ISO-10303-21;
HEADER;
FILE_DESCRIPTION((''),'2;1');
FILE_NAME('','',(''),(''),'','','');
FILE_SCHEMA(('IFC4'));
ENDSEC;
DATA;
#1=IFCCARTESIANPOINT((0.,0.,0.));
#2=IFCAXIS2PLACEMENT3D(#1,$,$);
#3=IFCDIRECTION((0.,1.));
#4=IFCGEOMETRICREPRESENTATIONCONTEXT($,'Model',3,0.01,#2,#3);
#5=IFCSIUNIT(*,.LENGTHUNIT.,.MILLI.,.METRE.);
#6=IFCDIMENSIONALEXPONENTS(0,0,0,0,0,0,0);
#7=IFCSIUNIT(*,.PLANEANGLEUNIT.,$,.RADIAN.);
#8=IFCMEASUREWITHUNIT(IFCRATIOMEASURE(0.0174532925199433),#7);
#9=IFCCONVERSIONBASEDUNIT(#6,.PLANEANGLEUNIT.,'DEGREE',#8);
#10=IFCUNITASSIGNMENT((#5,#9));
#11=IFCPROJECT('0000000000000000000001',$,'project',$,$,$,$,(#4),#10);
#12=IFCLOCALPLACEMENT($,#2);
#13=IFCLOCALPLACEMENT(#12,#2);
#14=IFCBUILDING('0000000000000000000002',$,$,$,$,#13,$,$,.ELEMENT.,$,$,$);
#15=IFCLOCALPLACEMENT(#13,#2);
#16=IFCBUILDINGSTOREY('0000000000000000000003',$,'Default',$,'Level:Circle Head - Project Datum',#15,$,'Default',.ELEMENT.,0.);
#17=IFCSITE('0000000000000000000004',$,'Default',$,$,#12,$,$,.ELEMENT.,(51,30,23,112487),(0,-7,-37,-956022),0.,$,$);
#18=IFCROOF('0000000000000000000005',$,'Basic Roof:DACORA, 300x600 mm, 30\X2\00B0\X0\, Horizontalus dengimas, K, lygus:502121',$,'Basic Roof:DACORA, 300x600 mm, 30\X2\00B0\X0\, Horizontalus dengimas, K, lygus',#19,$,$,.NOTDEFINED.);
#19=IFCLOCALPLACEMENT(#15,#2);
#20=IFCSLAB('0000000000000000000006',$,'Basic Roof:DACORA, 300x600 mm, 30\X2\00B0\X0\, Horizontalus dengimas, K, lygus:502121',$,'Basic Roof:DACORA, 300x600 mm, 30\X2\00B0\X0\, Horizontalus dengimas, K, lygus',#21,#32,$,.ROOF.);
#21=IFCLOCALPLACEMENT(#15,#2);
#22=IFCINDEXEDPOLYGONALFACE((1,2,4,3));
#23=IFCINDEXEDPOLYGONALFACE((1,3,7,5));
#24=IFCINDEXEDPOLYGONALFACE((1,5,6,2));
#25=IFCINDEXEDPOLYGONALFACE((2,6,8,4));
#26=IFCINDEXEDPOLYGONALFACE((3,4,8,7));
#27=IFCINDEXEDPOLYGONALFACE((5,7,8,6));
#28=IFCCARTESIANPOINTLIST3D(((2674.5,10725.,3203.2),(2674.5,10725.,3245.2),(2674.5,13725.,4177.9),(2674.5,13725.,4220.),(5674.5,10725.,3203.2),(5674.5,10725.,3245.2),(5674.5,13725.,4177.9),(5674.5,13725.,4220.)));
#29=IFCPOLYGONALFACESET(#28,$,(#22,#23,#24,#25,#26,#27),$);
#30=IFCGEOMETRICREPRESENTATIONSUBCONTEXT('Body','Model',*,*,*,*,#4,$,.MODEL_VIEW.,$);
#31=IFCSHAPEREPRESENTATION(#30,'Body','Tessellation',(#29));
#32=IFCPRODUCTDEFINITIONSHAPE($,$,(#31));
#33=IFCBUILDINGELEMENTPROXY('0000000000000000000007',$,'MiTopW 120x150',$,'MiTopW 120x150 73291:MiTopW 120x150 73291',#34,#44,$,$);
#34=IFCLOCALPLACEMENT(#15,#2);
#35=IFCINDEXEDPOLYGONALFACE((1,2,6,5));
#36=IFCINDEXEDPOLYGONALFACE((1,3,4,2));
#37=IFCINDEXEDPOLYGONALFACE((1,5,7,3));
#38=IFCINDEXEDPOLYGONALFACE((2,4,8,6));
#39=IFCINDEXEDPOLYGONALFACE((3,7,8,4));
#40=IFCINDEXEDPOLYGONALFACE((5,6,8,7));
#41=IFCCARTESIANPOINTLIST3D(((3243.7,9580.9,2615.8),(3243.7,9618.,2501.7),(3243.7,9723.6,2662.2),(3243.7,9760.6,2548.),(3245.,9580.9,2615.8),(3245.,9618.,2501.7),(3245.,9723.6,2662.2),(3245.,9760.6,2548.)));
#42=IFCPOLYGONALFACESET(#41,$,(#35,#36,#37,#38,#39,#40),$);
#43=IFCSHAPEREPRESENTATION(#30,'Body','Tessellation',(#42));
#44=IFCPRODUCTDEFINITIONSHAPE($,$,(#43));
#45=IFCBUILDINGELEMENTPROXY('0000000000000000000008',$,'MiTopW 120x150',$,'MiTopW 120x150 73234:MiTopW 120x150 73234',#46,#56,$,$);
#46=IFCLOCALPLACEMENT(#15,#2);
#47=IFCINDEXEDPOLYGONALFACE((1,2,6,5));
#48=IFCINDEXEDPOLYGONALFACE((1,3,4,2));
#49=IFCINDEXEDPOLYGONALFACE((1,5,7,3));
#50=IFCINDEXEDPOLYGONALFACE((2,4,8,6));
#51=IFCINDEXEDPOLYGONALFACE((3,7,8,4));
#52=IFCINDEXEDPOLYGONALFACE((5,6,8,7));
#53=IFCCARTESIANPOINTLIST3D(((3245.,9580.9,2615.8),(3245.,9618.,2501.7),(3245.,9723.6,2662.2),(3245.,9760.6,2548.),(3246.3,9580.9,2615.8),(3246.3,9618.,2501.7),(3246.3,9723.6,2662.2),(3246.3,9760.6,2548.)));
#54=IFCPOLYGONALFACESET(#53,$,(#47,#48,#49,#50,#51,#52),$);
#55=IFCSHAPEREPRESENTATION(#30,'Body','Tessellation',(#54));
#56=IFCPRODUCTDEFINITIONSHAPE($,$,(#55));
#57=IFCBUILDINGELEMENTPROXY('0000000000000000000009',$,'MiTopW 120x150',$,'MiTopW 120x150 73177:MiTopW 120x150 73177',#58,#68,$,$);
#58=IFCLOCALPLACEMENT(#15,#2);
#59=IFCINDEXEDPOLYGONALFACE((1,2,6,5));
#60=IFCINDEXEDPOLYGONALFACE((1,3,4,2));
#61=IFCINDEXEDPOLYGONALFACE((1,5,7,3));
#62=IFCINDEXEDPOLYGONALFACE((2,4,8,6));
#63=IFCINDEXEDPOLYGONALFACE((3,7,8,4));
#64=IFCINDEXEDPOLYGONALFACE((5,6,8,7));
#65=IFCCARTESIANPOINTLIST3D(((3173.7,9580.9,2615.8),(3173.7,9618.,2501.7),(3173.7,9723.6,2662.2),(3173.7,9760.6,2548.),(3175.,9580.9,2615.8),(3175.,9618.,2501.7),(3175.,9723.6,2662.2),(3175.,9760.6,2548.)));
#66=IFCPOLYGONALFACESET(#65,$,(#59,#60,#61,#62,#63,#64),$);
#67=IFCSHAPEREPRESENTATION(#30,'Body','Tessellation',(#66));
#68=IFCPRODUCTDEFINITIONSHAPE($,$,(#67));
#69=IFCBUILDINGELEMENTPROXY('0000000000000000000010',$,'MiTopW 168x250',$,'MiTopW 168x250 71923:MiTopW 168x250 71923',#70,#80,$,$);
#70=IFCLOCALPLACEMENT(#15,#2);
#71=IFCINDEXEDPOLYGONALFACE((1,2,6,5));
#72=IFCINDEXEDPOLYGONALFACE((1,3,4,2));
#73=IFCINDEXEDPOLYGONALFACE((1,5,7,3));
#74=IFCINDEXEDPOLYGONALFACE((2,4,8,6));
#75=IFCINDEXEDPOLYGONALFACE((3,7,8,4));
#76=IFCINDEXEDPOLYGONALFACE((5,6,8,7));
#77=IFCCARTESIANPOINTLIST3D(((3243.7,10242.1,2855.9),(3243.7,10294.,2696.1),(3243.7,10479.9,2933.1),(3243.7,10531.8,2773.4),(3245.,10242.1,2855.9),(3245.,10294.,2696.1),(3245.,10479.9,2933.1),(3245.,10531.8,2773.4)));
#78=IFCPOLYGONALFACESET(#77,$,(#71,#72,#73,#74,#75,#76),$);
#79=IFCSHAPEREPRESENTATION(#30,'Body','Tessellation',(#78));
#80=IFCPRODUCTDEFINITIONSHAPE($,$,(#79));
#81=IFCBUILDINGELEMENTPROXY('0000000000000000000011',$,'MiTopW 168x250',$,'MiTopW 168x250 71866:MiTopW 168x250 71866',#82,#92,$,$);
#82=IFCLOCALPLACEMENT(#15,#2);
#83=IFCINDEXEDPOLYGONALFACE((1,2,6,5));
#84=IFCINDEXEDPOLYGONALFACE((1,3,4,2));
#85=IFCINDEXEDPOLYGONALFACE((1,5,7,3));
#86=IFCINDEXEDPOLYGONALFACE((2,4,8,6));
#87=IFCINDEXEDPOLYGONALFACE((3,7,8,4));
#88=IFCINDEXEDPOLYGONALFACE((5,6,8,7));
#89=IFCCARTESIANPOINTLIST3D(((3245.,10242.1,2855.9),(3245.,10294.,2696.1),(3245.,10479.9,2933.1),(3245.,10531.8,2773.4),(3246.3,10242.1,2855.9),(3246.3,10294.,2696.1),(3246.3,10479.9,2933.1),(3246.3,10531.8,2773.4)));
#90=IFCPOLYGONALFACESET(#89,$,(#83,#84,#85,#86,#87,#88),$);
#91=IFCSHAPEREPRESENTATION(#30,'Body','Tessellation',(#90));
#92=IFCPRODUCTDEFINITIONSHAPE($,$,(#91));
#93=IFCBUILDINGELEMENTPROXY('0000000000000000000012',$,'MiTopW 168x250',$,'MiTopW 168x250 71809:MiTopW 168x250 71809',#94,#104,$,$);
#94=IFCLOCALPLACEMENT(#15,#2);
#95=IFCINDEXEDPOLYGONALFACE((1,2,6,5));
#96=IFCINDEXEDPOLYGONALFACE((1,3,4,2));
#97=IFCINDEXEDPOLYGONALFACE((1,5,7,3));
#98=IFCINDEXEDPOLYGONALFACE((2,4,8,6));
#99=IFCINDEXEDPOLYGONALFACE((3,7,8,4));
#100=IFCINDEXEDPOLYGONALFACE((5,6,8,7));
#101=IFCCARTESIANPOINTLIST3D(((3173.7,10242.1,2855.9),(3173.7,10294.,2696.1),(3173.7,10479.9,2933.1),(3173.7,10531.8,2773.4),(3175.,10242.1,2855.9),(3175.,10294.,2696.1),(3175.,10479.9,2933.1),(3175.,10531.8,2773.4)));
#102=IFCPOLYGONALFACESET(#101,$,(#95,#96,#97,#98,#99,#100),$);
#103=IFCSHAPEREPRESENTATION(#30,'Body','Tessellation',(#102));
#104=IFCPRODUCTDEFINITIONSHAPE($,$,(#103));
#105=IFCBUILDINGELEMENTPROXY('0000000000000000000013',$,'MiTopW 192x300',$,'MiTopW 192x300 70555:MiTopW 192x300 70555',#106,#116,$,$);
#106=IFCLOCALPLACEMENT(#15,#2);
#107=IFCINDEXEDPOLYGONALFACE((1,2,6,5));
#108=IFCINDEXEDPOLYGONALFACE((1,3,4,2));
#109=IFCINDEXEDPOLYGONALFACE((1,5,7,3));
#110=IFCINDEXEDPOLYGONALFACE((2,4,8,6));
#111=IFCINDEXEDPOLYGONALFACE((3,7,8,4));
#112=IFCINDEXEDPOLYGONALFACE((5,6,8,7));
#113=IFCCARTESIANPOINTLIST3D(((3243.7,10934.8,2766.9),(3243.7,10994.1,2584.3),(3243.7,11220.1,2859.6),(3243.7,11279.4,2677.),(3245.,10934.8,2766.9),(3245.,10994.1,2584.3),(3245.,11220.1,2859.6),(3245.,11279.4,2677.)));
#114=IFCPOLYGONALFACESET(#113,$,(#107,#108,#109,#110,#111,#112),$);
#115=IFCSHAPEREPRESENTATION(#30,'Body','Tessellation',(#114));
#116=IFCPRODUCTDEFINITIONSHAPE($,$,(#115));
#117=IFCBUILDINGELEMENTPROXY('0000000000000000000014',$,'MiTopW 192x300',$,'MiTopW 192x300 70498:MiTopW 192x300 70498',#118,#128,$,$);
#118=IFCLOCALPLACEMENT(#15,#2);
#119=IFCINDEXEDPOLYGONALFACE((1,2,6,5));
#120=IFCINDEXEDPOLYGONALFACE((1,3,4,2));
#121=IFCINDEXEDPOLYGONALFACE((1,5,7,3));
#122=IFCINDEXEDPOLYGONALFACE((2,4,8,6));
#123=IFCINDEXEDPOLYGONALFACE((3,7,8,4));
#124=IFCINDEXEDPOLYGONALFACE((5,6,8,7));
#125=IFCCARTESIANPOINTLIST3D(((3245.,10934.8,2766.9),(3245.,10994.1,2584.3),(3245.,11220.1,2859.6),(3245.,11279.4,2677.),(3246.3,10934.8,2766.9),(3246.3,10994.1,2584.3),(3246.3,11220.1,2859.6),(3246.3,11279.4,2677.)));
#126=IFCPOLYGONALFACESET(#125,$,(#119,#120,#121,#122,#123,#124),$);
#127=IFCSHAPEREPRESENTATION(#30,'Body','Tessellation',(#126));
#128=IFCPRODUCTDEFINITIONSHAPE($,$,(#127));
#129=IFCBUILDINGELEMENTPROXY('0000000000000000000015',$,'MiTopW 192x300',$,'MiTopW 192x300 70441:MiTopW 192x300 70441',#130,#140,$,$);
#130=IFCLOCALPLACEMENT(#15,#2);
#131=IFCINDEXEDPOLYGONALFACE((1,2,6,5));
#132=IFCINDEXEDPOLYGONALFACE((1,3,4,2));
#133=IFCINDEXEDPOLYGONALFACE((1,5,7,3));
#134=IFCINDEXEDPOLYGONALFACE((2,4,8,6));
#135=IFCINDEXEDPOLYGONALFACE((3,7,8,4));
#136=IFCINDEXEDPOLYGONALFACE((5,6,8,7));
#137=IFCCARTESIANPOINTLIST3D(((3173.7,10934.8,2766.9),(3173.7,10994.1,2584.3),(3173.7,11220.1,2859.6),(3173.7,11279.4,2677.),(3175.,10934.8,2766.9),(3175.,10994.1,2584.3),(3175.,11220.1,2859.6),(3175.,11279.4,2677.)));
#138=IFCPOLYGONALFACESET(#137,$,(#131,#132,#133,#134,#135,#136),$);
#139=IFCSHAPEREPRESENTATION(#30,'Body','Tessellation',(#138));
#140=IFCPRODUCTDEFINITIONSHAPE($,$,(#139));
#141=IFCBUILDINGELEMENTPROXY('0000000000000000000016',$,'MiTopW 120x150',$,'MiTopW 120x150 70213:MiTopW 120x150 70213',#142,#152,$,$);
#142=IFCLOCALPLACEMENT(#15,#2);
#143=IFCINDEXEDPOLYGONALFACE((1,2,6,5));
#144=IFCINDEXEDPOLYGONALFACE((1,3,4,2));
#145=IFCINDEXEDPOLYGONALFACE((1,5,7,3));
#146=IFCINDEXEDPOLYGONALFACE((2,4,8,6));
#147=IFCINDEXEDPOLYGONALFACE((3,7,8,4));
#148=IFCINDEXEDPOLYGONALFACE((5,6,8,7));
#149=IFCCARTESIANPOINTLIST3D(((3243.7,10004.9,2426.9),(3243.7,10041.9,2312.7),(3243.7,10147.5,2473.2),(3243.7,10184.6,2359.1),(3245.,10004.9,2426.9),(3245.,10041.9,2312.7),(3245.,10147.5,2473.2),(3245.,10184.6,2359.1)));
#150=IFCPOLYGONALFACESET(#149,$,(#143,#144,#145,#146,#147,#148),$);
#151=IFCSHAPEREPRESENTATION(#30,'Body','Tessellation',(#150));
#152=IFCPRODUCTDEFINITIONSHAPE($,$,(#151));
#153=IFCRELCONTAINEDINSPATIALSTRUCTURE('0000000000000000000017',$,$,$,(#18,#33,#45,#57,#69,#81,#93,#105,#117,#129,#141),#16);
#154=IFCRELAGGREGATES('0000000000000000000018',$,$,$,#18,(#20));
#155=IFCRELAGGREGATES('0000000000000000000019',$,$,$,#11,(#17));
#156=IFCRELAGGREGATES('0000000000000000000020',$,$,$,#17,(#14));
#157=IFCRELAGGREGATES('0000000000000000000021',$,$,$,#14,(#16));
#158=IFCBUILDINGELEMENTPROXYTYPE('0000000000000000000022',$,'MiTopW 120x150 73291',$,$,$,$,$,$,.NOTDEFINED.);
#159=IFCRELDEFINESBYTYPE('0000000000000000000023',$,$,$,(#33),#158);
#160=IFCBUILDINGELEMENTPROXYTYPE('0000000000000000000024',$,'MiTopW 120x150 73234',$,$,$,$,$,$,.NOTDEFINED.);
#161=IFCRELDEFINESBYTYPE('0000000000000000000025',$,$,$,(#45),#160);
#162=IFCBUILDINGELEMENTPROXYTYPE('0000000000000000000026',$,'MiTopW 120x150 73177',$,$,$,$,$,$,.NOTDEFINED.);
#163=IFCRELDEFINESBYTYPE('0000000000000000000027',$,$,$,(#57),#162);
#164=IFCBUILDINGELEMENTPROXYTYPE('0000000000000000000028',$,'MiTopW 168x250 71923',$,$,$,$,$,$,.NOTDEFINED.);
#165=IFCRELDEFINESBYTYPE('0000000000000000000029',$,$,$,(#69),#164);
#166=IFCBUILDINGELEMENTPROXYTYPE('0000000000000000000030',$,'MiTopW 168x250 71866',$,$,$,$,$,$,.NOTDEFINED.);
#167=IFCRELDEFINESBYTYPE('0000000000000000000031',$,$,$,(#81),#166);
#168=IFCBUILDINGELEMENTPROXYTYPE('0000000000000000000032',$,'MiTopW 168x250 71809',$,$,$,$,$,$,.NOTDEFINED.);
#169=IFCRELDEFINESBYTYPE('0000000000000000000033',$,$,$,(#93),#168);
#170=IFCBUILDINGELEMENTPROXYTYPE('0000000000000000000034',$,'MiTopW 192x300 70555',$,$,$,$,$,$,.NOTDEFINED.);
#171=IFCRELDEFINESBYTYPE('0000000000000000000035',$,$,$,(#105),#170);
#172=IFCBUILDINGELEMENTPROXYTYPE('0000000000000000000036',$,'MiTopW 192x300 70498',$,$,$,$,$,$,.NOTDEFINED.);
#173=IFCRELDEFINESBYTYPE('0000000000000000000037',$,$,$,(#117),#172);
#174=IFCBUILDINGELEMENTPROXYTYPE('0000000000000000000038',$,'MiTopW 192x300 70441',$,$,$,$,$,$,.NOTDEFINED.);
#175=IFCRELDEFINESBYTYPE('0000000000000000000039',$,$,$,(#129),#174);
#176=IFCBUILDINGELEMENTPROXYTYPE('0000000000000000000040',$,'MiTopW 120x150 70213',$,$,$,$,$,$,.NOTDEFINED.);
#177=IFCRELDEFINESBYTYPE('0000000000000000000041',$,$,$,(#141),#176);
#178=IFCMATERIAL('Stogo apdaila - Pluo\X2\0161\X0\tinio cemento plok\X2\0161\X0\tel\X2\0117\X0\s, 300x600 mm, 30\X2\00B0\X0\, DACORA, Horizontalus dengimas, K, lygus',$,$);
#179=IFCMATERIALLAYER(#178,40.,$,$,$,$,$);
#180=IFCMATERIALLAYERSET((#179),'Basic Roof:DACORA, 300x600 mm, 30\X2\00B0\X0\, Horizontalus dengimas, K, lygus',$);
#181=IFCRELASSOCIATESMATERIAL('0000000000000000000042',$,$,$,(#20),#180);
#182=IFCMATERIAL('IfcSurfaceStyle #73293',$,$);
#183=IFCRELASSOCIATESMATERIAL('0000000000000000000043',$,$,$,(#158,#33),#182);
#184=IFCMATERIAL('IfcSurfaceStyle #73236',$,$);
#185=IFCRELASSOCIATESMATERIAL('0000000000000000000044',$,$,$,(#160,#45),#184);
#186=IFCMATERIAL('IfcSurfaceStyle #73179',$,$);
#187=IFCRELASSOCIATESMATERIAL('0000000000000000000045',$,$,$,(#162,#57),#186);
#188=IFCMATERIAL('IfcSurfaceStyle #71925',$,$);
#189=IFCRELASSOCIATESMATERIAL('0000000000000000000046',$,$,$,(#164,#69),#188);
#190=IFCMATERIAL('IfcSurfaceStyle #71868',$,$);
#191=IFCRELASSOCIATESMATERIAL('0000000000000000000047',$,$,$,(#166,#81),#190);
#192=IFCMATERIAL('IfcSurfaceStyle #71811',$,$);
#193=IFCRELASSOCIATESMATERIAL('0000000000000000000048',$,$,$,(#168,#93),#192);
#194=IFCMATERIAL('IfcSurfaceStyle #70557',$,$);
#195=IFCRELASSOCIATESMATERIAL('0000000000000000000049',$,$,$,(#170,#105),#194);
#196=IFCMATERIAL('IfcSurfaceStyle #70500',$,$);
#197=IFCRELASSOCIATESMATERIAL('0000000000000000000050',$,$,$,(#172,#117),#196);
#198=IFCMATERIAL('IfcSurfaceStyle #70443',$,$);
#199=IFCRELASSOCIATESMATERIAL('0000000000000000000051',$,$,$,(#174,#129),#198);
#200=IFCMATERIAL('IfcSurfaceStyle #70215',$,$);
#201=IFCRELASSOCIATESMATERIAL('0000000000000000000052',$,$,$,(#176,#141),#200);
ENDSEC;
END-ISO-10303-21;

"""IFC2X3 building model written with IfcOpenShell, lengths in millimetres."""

from ifc_helpers import new_model, entity, si_unit, converted_unit, direction, frame, frame_2d, origin, place, context, subcontext, project, spatial, polyline, rectangle, outline, extrude, source, transform, mapped, material, layer, layer_set, type_object, type_shapes, element, aggregate, save


model = new_model("IFC2X3")

# Units and contexts
model_context = context("Model", 3, precision=0.01, world=origin(), true_north=direction((0.0, 1.0)))
body_context = subcontext(model_context, "Body", "Model", "MODEL_VIEW")
ifc_project = project(units=[si_unit("LENGTHUNIT", "METRE", prefix="MILLI"), converted_unit("PLANEANGLEUNIT", "DEGREE", entity("IfcRatioMeasure", 0.0174532925199433), si_unit("PLANEANGLEUNIT", "RADIAN"), dimensions=[0, 0, 0, 0, 0, 0, 0])], contexts=[model_context])

# Site, building, storey
site_placement = place(None, origin())
site = spatial("IfcSite", under=ifc_project, at=site_placement, Name="Default", CompositionType="ELEMENT", RefLatitude=(51, 30, 23, 112487), RefLongitude=(0, -7, -37, -956022), RefElevation=0.0)
building_placement = place(site_placement, origin())
building = spatial("IfcBuilding", under=site, at=building_placement, CompositionType="ELEMENT")
storey_placement = place(building_placement, origin())
storey = spatial("IfcBuildingStorey", under=building, at=storey_placement, Name="Default", ObjectType="Level:Circle Head - Project Datum", LongName="Default", CompositionType="ELEMENT", Elevation=0.0)

# Roof, slab
roof_placement = place(storey_placement, frame((2674.5, 10725.0, 3203.2)))
roof = element("IfcRoof", 1, at=roof_placement, inside=storey, Name="Basic Roof:DACORA, 300x600 mm, 30°, Horizontalus dengimas, K, lygus:502121", ObjectType="Basic Roof:DACORA, 300x600 mm, 30°, Horizontalus dengimas, K, lygus", ShapeType="NOTDEFINED")
ifc_material_1 = material(Name="Stogo apdaila - Pluoštinio cemento plokštelės, 300x600 mm, 30°, DACORA, Horizontalus dengimas, K, lygus")
ifc_layer = layer(ifc_material_1, 40.0)
ifc_layer_set = layer_set([ifc_layer], Name="Basic Roof:DACORA, 300x600 mm, 30°, Horizontalus dengimas, K, lygus")
slab_placement = place(roof_placement, origin())
slab = element("IfcSlab", 2, at=slab_placement, material=ifc_layer_set, Name="Basic Roof:DACORA, 300x600 mm, 30°, Horizontalus dengimas, K, lygus:502121", ObjectType="Basic Roof:DACORA, 300x600 mm, 30°, Horizontalus dengimas, K, lygus", PredefinedType="ROOF", context=body_context, shape_type="SweptSolid", body=[
    extrude(rectangle(XDim=3154.4, YDim=3000.0, at=frame_2d((0.0, 0.0), x_axis=(0.0, -1.0))), frame((1500.0, 1500.0, 487.4), z_axis=(0.0, -0.309017, 0.951057), x_axis=(1.0, 0.0, 0.0)), (0.0, 0.309017, 0.951057), 42.1),
])
aggregate(roof, [slab])

# Building element proxies
ifc_material_2 = material(Name="IfcSurfaceStyle #73293")
building_element_proxy_type_1 = type_object("IfcBuildingElementProxyType", Name="MiTopW 120x150 73291", PredefinedType="NOTDEFINED", material=ifc_material_2)
shared_shape_1 = source(origin(), body_context, "Body", "SweptSolid", [
    extrude(outline(polyline([(-75.0, -60.0), (75.0, -60.0), (75.0, 60.0), (-75.0, 60.0), (-75.0, -60.0)])), frame((75.0, 60.0, 0.0), z_axis=(0.0, 0.0, 1.0), x_axis=(-1.0, 0.0, 0.0)), (0.0, 0.0, 1.0), 1.3),
])
type_shapes(building_element_proxy_type_1, [shared_shape_1])
proxy_1_placement = place(building_placement, frame((3245.0, 9580.9, 2615.8), z_axis=(-1.0, 0.0, 0.0), x_axis=(0.0, 0.951057, 0.309017)))
element("IfcBuildingElementProxy", 3, at=proxy_1_placement, inside=storey, type_object=building_element_proxy_type_1, material=ifc_material_2, Name="MiTopW 120x150", ObjectType="MiTopW 120x150 73291:MiTopW 120x150 73291", context=body_context, shape_type="MappedRepresentation", body=[
    mapped(shared_shape_1, transform((0.0, 0.0, 0.0), scale=1.0)),
])
ifc_material_3 = material(Name="IfcSurfaceStyle #73236")
building_element_proxy_type_2 = type_object("IfcBuildingElementProxyType", Name="MiTopW 120x150 73234", PredefinedType="NOTDEFINED", material=ifc_material_3)
shared_shape_2 = source(origin(), body_context, "Body", "SweptSolid", [
    extrude(outline(polyline([(-75.0, -60.0), (75.0, -60.0), (75.0, 60.0), (-75.0, 60.0), (-75.0, -60.0)])), frame((75.0, 60.0, 0.0), z_axis=(0.0, 0.0, 1.0), x_axis=(-1.0, 0.0, 0.0)), (0.0, 0.0, 1.0), 1.3),
])
type_shapes(building_element_proxy_type_2, [shared_shape_2])
proxy_2_placement = place(building_placement, frame((3246.3, 9580.9, 2615.8), z_axis=(-1.0, 0.0, 0.0), x_axis=(0.0, 0.951057, 0.309017)))
element("IfcBuildingElementProxy", 4, at=proxy_2_placement, inside=storey, type_object=building_element_proxy_type_2, material=ifc_material_3, Name="MiTopW 120x150", ObjectType="MiTopW 120x150 73234:MiTopW 120x150 73234", context=body_context, shape_type="MappedRepresentation", body=[
    mapped(shared_shape_2, transform((0.0, 0.0, 0.0), scale=1.0)),
])
ifc_material_4 = material(Name="IfcSurfaceStyle #73179")
building_element_proxy_type_3 = type_object("IfcBuildingElementProxyType", Name="MiTopW 120x150 73177", PredefinedType="NOTDEFINED", material=ifc_material_4)
shared_shape_3 = source(origin(), body_context, "Body", "SweptSolid", [
    extrude(outline(polyline([(-75.0, -60.0), (75.0, -60.0), (75.0, 60.0), (-75.0, 60.0), (-75.0, -60.0)])), frame((75.0, 60.0, 0.0), z_axis=(0.0, 0.0, 1.0), x_axis=(-1.0, 0.0, 0.0)), (0.0, 0.0, 1.0), 1.3),
])
type_shapes(building_element_proxy_type_3, [shared_shape_3])
proxy_3_placement = place(building_placement, frame((3175.0, 9580.9, 2615.8), z_axis=(-1.0, 0.0, 0.0), x_axis=(0.0, 0.951057, 0.309017)))
element("IfcBuildingElementProxy", 5, at=proxy_3_placement, inside=storey, type_object=building_element_proxy_type_3, material=ifc_material_4, Name="MiTopW 120x150", ObjectType="MiTopW 120x150 73177:MiTopW 120x150 73177", context=body_context, shape_type="MappedRepresentation", body=[
    mapped(shared_shape_3, transform((0.0, 0.0, 0.0), scale=1.0)),
])
ifc_material_5 = material(Name="IfcSurfaceStyle #71925")
building_element_proxy_type_4 = type_object("IfcBuildingElementProxyType", Name="MiTopW 168x250 71923", PredefinedType="NOTDEFINED", material=ifc_material_5)
shared_shape_4 = source(origin(), body_context, "Body", "SweptSolid", [
    extrude(outline(polyline([(-125.0, -84.0), (125.0, -84.0), (125.0, 84.0), (-125.0, 84.0), (-125.0, -84.0)])), frame((125.0, 84.0, 0.0), z_axis=(0.0, 0.0, 1.0), x_axis=(-1.0, 0.0, 0.0)), (0.0, 0.0, 1.0), 1.3),
])
type_shapes(building_element_proxy_type_4, [shared_shape_4])
proxy_4_placement = place(building_placement, frame((3245.0, 10242.1, 2855.9), z_axis=(-1.0, 0.0, 0.0), x_axis=(0.0, 0.951057, 0.309017)))
element("IfcBuildingElementProxy", 6, at=proxy_4_placement, inside=storey, type_object=building_element_proxy_type_4, material=ifc_material_5, Name="MiTopW 168x250", ObjectType="MiTopW 168x250 71923:MiTopW 168x250 71923", context=body_context, shape_type="MappedRepresentation", body=[
    mapped(shared_shape_4, transform((0.0, 0.0, 0.0), scale=1.0)),
])
ifc_material_6 = material(Name="IfcSurfaceStyle #71868")
building_element_proxy_type_5 = type_object("IfcBuildingElementProxyType", Name="MiTopW 168x250 71866", PredefinedType="NOTDEFINED", material=ifc_material_6)
shared_shape_5 = source(origin(), body_context, "Body", "SweptSolid", [
    extrude(outline(polyline([(-125.0, -84.0), (125.0, -84.0), (125.0, 84.0), (-125.0, 84.0), (-125.0, -84.0)])), frame((125.0, 84.0, 0.0), z_axis=(0.0, 0.0, 1.0), x_axis=(-1.0, 0.0, 0.0)), (0.0, 0.0, 1.0), 1.3),
])
type_shapes(building_element_proxy_type_5, [shared_shape_5])
proxy_5_placement = place(building_placement, frame((3246.3, 10242.1, 2855.9), z_axis=(-1.0, 0.0, 0.0), x_axis=(0.0, 0.951057, 0.309017)))
element("IfcBuildingElementProxy", 7, at=proxy_5_placement, inside=storey, type_object=building_element_proxy_type_5, material=ifc_material_6, Name="MiTopW 168x250", ObjectType="MiTopW 168x250 71866:MiTopW 168x250 71866", context=body_context, shape_type="MappedRepresentation", body=[
    mapped(shared_shape_5, transform((0.0, 0.0, 0.0), scale=1.0)),
])
ifc_material_7 = material(Name="IfcSurfaceStyle #71811")
building_element_proxy_type_6 = type_object("IfcBuildingElementProxyType", Name="MiTopW 168x250 71809", PredefinedType="NOTDEFINED", material=ifc_material_7)
shared_shape_6 = source(origin(), body_context, "Body", "SweptSolid", [
    extrude(outline(polyline([(-125.0, -84.0), (125.0, -84.0), (125.0, 84.0), (-125.0, 84.0), (-125.0, -84.0)])), frame((125.0, 84.0, 0.0), z_axis=(0.0, 0.0, 1.0), x_axis=(-1.0, 0.0, 0.0)), (0.0, 0.0, 1.0), 1.3),
])
type_shapes(building_element_proxy_type_6, [shared_shape_6])
proxy_6_placement = place(building_placement, frame((3175.0, 10242.1, 2855.9), z_axis=(-1.0, 0.0, 0.0), x_axis=(0.0, 0.951057, 0.309017)))
element("IfcBuildingElementProxy", 8, at=proxy_6_placement, inside=storey, type_object=building_element_proxy_type_6, material=ifc_material_7, Name="MiTopW 168x250", ObjectType="MiTopW 168x250 71809:MiTopW 168x250 71809", context=body_context, shape_type="MappedRepresentation", body=[
    mapped(shared_shape_6, transform((0.0, 0.0, 0.0), scale=1.0)),
])
ifc_material_8 = material(Name="IfcSurfaceStyle #70557")
building_element_proxy_type_7 = type_object("IfcBuildingElementProxyType", Name="MiTopW 192x300 70555", PredefinedType="NOTDEFINED", material=ifc_material_8)
shared_shape_7 = source(origin(), body_context, "Body", "SweptSolid", [
    extrude(outline(polyline([(-150.0, -96.0), (150.0, -96.0), (150.0, 96.0), (-150.0, 96.0), (-150.0, -96.0)])), frame((150.0, 96.0, 0.0), z_axis=(0.0, 0.0, 1.0), x_axis=(-1.0, 0.0, 0.0)), (0.0, 0.0, 1.0), 1.3),
])
type_shapes(building_element_proxy_type_7, [shared_shape_7])
proxy_7_placement = place(building_placement, frame((3245.0, 10934.8, 2766.9), z_axis=(-1.0, 0.0, 0.0), x_axis=(0.0, 0.951057, 0.309017)))
element("IfcBuildingElementProxy", 9, at=proxy_7_placement, inside=storey, type_object=building_element_proxy_type_7, material=ifc_material_8, Name="MiTopW 192x300", ObjectType="MiTopW 192x300 70555:MiTopW 192x300 70555", context=body_context, shape_type="MappedRepresentation", body=[
    mapped(shared_shape_7, transform((0.0, 0.0, 0.0), scale=1.0)),
])
ifc_material_9 = material(Name="IfcSurfaceStyle #70500")
building_element_proxy_type_8 = type_object("IfcBuildingElementProxyType", Name="MiTopW 192x300 70498", PredefinedType="NOTDEFINED", material=ifc_material_9)
shared_shape_8 = source(origin(), body_context, "Body", "SweptSolid", [
    extrude(outline(polyline([(-150.0, -96.0), (150.0, -96.0), (150.0, 96.0), (-150.0, 96.0), (-150.0, -96.0)])), frame((150.0, 96.0, 0.0), z_axis=(0.0, 0.0, 1.0), x_axis=(-1.0, 0.0, 0.0)), (0.0, 0.0, 1.0), 1.3),
])
type_shapes(building_element_proxy_type_8, [shared_shape_8])
proxy_8_placement = place(building_placement, frame((3246.3, 10934.8, 2766.9), z_axis=(-1.0, 0.0, 0.0), x_axis=(0.0, 0.951057, 0.309017)))
element("IfcBuildingElementProxy", 10, at=proxy_8_placement, inside=storey, type_object=building_element_proxy_type_8, material=ifc_material_9, Name="MiTopW 192x300", ObjectType="MiTopW 192x300 70498:MiTopW 192x300 70498", context=body_context, shape_type="MappedRepresentation", body=[
    mapped(shared_shape_8, transform((0.0, 0.0, 0.0), scale=1.0)),
])
ifc_material_10 = material(Name="IfcSurfaceStyle #70443")
building_element_proxy_type_9 = type_object("IfcBuildingElementProxyType", Name="MiTopW 192x300 70441", PredefinedType="NOTDEFINED", material=ifc_material_10)
shared_shape_9 = source(origin(), body_context, "Body", "SweptSolid", [
    extrude(outline(polyline([(-150.0, -96.0), (150.0, -96.0), (150.0, 96.0), (-150.0, 96.0), (-150.0, -96.0)])), frame((150.0, 96.0, 0.0), z_axis=(0.0, 0.0, 1.0), x_axis=(-1.0, 0.0, 0.0)), (0.0, 0.0, 1.0), 1.3),
])
type_shapes(building_element_proxy_type_9, [shared_shape_9])
proxy_9_placement = place(building_placement, frame((3175.0, 10934.8, 2766.9), z_axis=(-1.0, 0.0, 0.0), x_axis=(0.0, 0.951057, 0.309017)))
element("IfcBuildingElementProxy", 11, at=proxy_9_placement, inside=storey, type_object=building_element_proxy_type_9, material=ifc_material_10, Name="MiTopW 192x300", ObjectType="MiTopW 192x300 70441:MiTopW 192x300 70441", context=body_context, shape_type="MappedRepresentation", body=[
    mapped(shared_shape_9, transform((0.0, 0.0, 0.0), scale=1.0)),
])
ifc_material_11 = material(Name="IfcSurfaceStyle #70215")
building_element_proxy_type_10 = type_object("IfcBuildingElementProxyType", Name="MiTopW 120x150 70213", PredefinedType="NOTDEFINED", material=ifc_material_11)
shared_shape_10 = source(origin(), body_context, "Body", "SweptSolid", [
    extrude(outline(polyline([(-75.0, -60.0), (75.0, -60.0), (75.0, 60.0), (-75.0, 60.0), (-75.0, -60.0)])), frame((75.0, 60.0, 0.0), z_axis=(0.0, 0.0, 1.0), x_axis=(-1.0, 0.0, 0.0)), (0.0, 0.0, 1.0), 1.3),
])
type_shapes(building_element_proxy_type_10, [shared_shape_10])
proxy_10_placement = place(building_placement, frame((3245.0, 10004.9, 2426.9), z_axis=(-1.0, 0.0, 0.0), x_axis=(0.0, 0.951057, 0.309017)))
element("IfcBuildingElementProxy", 12, at=proxy_10_placement, inside=storey, type_object=building_element_proxy_type_10, material=ifc_material_11, Name="MiTopW 120x150", ObjectType="MiTopW 120x150 70213:MiTopW 120x150 70213", context=body_context, shape_type="MappedRepresentation", body=[
    mapped(shared_shape_10, transform((0.0, 0.0, 0.0), scale=1.0)),
])

save(model, "model.ifc")
